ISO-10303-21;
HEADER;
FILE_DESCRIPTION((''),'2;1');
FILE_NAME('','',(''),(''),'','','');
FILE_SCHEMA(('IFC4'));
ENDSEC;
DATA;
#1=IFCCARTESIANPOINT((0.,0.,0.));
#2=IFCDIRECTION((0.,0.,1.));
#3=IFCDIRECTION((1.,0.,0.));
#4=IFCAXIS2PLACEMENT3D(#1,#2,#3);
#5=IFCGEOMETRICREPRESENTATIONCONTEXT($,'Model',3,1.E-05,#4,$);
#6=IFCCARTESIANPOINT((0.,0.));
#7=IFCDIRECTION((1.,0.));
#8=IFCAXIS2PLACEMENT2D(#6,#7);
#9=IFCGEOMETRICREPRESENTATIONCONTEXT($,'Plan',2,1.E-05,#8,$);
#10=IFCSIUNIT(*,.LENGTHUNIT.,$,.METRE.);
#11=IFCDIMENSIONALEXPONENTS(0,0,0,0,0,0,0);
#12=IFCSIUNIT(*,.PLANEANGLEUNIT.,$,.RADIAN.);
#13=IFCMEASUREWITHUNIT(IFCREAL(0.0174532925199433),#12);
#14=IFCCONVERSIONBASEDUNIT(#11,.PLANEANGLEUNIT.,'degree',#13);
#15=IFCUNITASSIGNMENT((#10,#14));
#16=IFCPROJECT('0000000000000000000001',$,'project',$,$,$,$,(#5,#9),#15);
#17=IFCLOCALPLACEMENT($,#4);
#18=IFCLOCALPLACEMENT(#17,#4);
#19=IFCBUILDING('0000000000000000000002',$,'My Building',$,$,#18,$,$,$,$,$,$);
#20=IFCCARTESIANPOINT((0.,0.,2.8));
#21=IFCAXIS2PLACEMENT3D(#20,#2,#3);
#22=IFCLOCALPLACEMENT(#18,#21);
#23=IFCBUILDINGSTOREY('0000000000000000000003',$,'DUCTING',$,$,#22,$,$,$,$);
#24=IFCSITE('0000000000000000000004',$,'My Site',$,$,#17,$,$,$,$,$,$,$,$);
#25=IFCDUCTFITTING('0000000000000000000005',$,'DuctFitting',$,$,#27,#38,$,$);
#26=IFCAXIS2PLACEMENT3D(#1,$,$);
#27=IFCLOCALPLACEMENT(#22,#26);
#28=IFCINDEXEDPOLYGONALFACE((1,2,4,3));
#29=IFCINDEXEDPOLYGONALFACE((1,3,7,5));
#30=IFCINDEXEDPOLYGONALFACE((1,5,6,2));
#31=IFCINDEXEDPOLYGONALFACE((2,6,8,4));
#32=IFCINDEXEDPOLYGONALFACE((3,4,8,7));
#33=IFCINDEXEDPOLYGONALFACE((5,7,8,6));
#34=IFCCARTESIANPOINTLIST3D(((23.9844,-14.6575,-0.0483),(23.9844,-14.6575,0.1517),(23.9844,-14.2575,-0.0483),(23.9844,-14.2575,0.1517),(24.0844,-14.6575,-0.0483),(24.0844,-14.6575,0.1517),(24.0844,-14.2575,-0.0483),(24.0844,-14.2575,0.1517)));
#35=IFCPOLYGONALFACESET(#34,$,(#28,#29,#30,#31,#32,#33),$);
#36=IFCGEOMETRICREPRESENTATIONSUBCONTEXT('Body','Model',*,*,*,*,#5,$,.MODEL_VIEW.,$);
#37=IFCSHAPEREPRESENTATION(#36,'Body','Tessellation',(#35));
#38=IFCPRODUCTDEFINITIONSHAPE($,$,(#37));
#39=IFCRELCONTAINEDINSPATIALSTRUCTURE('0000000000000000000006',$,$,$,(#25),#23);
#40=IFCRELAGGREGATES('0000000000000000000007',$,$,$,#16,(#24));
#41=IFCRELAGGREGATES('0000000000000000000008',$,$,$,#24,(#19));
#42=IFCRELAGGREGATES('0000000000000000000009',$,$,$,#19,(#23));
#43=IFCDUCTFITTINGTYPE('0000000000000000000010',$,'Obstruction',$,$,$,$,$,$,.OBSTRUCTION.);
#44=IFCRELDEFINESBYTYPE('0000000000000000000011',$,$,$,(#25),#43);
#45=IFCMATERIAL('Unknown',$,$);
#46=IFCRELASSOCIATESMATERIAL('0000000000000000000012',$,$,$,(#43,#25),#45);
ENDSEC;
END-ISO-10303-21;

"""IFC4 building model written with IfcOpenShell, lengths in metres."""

from ifc_helpers import new_model, entity, si_unit, converted_unit, frame, origin_with_axes, origin_2d_with_axis, place, context, subcontext, project, spatial, rectangle, extrude, material, material_profile, profile_set, profile_usage, type_object, element, save


model = new_model("IFC4")

# Units and contexts
model_context = context("Model", 3, precision=1e-05, world=origin_with_axes())
plan_context = context("Plan", 2, precision=1e-05, world=origin_2d_with_axis())
body_context = subcontext(model_context, "Body", "Model", "MODEL_VIEW")
ifc_project = project(units=[si_unit("LENGTHUNIT", "METRE"), converted_unit("PLANEANGLEUNIT", "degree", entity("IfcReal", 0.0174532925199433), si_unit("PLANEANGLEUNIT", "RADIAN"), dimensions=[0, 0, 0, 0, 0, 0, 0])], contexts=[model_context, plan_context])

# Site, building, storey
site_placement = place(None, origin_with_axes())
site = spatial("IfcSite", under=ifc_project, at=site_placement, Name="My Site")
building_placement = place(site_placement, origin_with_axes())
building = spatial("IfcBuilding", under=site, at=building_placement, Name="My Building")
storey_placement = place(building_placement, frame((0.0, 0.0, 2.8), z_axis=(0.0, 0.0, 1.0), x_axis=(1.0, 0.0, 0.0)))
storey = spatial("IfcBuildingStorey", under=building, at=storey_placement, Name="DUCTING")

# Shared definitions
ifc_material = material(Name="Unknown")

# Duct fitting
ifc_material_profile_1 = material_profile(ifc_material, rectangle(XDim=0.4, YDim=0.2))
ifc_profile_set_1 = profile_set([ifc_material_profile_1])
duct_fitting_type_1 = type_object("IfcDuctFittingType", Name="Obstruction", PredefinedType="OBSTRUCTION", material=ifc_profile_set_1)
ifc_profile_usage_1 = profile_usage(ifc_profile_set_1, cardinal=5)
duct_fitting_1_placement = place(storey_placement, frame((24.0844, -14.4575, 0.0517), z_axis=(-1.0, 0.0, 0.0), x_axis=(0.0, -1.0, 0.0)))
element("IfcDuctFitting", 1, at=duct_fitting_1_placement, inside=storey, type_object=duct_fitting_type_1, material=ifc_profile_usage_1, Name="DuctFitting", context=body_context, shape_type="SweptSolid", body=[
    extrude(rectangle(XDim=0.4, YDim=0.2), origin_with_axes(), (0.0, 0.0, 1.0), 0.1),
])

save(model, "model.ifc")
